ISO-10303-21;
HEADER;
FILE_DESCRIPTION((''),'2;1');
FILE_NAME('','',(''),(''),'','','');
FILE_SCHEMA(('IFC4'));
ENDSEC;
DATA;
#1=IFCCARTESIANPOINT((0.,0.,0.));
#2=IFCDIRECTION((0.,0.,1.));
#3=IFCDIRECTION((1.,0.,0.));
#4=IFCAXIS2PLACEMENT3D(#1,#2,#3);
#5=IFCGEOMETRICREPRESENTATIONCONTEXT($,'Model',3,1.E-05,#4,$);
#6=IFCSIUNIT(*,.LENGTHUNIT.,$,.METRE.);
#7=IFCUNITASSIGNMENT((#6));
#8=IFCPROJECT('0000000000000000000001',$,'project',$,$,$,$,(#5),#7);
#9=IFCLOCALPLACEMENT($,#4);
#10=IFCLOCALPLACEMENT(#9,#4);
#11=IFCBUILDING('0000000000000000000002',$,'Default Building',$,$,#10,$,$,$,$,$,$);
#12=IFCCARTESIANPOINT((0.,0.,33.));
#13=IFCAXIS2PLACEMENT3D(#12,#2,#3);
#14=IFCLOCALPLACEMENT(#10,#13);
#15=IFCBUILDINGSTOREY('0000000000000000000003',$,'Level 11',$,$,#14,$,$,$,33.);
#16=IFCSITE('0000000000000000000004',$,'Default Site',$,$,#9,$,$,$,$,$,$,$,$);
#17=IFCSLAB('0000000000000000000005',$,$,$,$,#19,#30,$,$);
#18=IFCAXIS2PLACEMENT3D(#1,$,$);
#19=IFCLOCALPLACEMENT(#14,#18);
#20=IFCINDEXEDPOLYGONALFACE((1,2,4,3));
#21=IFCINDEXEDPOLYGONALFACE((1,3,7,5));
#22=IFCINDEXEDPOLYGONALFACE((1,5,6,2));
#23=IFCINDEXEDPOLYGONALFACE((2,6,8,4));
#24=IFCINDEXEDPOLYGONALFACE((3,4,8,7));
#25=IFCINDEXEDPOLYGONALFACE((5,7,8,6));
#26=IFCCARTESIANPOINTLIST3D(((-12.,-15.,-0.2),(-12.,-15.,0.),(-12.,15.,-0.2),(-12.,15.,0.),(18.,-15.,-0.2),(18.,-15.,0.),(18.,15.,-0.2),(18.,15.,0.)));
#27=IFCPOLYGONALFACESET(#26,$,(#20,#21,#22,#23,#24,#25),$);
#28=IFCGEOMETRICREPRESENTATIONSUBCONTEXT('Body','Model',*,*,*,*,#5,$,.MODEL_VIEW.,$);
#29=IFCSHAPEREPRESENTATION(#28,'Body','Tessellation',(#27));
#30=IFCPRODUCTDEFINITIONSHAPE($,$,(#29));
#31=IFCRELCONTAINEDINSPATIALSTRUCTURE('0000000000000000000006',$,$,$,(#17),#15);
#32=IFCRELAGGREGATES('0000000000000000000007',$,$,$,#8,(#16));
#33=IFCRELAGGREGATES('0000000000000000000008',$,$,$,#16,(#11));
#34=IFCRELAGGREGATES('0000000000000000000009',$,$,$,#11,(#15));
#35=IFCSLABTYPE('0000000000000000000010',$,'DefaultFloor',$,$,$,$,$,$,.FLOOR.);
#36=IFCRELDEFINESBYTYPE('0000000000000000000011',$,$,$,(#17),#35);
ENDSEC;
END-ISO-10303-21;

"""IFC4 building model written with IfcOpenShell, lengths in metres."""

from ifc_helpers import new_model, si_unit, frame, origin_with_axes, place, context, subcontext, project, spatial, polyline, outline, extrude, type_object, element, save


model = new_model("IFC4")

# Units and contexts
model_context = context("Model", 3, precision=1e-05, world=origin_with_axes())
body_context = subcontext(model_context, "Body", "Model", "MODEL_VIEW")
ifc_project = project(units=[si_unit("LENGTHUNIT", "METRE")], contexts=[model_context])

# Site, building, storey
site_placement = place(None, origin_with_axes())
site = spatial("IfcSite", under=ifc_project, at=site_placement, Name="Default Site")
building_placement = place(site_placement, origin_with_axes())
building = spatial("IfcBuilding", under=site, at=building_placement, Name="Default Building")
storey_placement = place(building_placement, frame((0.0, 0.0, 33.0), z_axis=(0.0, 0.0, 1.0), x_axis=(1.0, 0.0, 0.0)))
storey = spatial("IfcBuildingStorey", under=building, at=storey_placement, Name="Level 11", Elevation=33.0)

# Slab
slab_type = type_object("IfcSlabType", Name="DefaultFloor", PredefinedType="FLOOR")
slab_placement = place(storey_placement, frame((0.0, 0.0, -33.0), z_axis=(0.0, 0.0, 1.0), x_axis=(1.0, 0.0, 0.0)))
element("IfcSlab", 1, at=slab_placement, inside=storey, type_object=slab_type, context=body_context, shape_type="SweptSolid", body=[
    extrude(outline(polyline([(-12.0, 15.0), (18.0, 15.0), (18.0, -15.0), (-12.0, -15.0), (-12.0, 15.0)])), frame((0.0, 0.0, 33.0), z_axis=(0.0, 0.0, 1.0), x_axis=(1.0, 0.0, 0.0)), (0.0, 0.0, -1.0), 0.2),
])

save(model, "model.ifc")
